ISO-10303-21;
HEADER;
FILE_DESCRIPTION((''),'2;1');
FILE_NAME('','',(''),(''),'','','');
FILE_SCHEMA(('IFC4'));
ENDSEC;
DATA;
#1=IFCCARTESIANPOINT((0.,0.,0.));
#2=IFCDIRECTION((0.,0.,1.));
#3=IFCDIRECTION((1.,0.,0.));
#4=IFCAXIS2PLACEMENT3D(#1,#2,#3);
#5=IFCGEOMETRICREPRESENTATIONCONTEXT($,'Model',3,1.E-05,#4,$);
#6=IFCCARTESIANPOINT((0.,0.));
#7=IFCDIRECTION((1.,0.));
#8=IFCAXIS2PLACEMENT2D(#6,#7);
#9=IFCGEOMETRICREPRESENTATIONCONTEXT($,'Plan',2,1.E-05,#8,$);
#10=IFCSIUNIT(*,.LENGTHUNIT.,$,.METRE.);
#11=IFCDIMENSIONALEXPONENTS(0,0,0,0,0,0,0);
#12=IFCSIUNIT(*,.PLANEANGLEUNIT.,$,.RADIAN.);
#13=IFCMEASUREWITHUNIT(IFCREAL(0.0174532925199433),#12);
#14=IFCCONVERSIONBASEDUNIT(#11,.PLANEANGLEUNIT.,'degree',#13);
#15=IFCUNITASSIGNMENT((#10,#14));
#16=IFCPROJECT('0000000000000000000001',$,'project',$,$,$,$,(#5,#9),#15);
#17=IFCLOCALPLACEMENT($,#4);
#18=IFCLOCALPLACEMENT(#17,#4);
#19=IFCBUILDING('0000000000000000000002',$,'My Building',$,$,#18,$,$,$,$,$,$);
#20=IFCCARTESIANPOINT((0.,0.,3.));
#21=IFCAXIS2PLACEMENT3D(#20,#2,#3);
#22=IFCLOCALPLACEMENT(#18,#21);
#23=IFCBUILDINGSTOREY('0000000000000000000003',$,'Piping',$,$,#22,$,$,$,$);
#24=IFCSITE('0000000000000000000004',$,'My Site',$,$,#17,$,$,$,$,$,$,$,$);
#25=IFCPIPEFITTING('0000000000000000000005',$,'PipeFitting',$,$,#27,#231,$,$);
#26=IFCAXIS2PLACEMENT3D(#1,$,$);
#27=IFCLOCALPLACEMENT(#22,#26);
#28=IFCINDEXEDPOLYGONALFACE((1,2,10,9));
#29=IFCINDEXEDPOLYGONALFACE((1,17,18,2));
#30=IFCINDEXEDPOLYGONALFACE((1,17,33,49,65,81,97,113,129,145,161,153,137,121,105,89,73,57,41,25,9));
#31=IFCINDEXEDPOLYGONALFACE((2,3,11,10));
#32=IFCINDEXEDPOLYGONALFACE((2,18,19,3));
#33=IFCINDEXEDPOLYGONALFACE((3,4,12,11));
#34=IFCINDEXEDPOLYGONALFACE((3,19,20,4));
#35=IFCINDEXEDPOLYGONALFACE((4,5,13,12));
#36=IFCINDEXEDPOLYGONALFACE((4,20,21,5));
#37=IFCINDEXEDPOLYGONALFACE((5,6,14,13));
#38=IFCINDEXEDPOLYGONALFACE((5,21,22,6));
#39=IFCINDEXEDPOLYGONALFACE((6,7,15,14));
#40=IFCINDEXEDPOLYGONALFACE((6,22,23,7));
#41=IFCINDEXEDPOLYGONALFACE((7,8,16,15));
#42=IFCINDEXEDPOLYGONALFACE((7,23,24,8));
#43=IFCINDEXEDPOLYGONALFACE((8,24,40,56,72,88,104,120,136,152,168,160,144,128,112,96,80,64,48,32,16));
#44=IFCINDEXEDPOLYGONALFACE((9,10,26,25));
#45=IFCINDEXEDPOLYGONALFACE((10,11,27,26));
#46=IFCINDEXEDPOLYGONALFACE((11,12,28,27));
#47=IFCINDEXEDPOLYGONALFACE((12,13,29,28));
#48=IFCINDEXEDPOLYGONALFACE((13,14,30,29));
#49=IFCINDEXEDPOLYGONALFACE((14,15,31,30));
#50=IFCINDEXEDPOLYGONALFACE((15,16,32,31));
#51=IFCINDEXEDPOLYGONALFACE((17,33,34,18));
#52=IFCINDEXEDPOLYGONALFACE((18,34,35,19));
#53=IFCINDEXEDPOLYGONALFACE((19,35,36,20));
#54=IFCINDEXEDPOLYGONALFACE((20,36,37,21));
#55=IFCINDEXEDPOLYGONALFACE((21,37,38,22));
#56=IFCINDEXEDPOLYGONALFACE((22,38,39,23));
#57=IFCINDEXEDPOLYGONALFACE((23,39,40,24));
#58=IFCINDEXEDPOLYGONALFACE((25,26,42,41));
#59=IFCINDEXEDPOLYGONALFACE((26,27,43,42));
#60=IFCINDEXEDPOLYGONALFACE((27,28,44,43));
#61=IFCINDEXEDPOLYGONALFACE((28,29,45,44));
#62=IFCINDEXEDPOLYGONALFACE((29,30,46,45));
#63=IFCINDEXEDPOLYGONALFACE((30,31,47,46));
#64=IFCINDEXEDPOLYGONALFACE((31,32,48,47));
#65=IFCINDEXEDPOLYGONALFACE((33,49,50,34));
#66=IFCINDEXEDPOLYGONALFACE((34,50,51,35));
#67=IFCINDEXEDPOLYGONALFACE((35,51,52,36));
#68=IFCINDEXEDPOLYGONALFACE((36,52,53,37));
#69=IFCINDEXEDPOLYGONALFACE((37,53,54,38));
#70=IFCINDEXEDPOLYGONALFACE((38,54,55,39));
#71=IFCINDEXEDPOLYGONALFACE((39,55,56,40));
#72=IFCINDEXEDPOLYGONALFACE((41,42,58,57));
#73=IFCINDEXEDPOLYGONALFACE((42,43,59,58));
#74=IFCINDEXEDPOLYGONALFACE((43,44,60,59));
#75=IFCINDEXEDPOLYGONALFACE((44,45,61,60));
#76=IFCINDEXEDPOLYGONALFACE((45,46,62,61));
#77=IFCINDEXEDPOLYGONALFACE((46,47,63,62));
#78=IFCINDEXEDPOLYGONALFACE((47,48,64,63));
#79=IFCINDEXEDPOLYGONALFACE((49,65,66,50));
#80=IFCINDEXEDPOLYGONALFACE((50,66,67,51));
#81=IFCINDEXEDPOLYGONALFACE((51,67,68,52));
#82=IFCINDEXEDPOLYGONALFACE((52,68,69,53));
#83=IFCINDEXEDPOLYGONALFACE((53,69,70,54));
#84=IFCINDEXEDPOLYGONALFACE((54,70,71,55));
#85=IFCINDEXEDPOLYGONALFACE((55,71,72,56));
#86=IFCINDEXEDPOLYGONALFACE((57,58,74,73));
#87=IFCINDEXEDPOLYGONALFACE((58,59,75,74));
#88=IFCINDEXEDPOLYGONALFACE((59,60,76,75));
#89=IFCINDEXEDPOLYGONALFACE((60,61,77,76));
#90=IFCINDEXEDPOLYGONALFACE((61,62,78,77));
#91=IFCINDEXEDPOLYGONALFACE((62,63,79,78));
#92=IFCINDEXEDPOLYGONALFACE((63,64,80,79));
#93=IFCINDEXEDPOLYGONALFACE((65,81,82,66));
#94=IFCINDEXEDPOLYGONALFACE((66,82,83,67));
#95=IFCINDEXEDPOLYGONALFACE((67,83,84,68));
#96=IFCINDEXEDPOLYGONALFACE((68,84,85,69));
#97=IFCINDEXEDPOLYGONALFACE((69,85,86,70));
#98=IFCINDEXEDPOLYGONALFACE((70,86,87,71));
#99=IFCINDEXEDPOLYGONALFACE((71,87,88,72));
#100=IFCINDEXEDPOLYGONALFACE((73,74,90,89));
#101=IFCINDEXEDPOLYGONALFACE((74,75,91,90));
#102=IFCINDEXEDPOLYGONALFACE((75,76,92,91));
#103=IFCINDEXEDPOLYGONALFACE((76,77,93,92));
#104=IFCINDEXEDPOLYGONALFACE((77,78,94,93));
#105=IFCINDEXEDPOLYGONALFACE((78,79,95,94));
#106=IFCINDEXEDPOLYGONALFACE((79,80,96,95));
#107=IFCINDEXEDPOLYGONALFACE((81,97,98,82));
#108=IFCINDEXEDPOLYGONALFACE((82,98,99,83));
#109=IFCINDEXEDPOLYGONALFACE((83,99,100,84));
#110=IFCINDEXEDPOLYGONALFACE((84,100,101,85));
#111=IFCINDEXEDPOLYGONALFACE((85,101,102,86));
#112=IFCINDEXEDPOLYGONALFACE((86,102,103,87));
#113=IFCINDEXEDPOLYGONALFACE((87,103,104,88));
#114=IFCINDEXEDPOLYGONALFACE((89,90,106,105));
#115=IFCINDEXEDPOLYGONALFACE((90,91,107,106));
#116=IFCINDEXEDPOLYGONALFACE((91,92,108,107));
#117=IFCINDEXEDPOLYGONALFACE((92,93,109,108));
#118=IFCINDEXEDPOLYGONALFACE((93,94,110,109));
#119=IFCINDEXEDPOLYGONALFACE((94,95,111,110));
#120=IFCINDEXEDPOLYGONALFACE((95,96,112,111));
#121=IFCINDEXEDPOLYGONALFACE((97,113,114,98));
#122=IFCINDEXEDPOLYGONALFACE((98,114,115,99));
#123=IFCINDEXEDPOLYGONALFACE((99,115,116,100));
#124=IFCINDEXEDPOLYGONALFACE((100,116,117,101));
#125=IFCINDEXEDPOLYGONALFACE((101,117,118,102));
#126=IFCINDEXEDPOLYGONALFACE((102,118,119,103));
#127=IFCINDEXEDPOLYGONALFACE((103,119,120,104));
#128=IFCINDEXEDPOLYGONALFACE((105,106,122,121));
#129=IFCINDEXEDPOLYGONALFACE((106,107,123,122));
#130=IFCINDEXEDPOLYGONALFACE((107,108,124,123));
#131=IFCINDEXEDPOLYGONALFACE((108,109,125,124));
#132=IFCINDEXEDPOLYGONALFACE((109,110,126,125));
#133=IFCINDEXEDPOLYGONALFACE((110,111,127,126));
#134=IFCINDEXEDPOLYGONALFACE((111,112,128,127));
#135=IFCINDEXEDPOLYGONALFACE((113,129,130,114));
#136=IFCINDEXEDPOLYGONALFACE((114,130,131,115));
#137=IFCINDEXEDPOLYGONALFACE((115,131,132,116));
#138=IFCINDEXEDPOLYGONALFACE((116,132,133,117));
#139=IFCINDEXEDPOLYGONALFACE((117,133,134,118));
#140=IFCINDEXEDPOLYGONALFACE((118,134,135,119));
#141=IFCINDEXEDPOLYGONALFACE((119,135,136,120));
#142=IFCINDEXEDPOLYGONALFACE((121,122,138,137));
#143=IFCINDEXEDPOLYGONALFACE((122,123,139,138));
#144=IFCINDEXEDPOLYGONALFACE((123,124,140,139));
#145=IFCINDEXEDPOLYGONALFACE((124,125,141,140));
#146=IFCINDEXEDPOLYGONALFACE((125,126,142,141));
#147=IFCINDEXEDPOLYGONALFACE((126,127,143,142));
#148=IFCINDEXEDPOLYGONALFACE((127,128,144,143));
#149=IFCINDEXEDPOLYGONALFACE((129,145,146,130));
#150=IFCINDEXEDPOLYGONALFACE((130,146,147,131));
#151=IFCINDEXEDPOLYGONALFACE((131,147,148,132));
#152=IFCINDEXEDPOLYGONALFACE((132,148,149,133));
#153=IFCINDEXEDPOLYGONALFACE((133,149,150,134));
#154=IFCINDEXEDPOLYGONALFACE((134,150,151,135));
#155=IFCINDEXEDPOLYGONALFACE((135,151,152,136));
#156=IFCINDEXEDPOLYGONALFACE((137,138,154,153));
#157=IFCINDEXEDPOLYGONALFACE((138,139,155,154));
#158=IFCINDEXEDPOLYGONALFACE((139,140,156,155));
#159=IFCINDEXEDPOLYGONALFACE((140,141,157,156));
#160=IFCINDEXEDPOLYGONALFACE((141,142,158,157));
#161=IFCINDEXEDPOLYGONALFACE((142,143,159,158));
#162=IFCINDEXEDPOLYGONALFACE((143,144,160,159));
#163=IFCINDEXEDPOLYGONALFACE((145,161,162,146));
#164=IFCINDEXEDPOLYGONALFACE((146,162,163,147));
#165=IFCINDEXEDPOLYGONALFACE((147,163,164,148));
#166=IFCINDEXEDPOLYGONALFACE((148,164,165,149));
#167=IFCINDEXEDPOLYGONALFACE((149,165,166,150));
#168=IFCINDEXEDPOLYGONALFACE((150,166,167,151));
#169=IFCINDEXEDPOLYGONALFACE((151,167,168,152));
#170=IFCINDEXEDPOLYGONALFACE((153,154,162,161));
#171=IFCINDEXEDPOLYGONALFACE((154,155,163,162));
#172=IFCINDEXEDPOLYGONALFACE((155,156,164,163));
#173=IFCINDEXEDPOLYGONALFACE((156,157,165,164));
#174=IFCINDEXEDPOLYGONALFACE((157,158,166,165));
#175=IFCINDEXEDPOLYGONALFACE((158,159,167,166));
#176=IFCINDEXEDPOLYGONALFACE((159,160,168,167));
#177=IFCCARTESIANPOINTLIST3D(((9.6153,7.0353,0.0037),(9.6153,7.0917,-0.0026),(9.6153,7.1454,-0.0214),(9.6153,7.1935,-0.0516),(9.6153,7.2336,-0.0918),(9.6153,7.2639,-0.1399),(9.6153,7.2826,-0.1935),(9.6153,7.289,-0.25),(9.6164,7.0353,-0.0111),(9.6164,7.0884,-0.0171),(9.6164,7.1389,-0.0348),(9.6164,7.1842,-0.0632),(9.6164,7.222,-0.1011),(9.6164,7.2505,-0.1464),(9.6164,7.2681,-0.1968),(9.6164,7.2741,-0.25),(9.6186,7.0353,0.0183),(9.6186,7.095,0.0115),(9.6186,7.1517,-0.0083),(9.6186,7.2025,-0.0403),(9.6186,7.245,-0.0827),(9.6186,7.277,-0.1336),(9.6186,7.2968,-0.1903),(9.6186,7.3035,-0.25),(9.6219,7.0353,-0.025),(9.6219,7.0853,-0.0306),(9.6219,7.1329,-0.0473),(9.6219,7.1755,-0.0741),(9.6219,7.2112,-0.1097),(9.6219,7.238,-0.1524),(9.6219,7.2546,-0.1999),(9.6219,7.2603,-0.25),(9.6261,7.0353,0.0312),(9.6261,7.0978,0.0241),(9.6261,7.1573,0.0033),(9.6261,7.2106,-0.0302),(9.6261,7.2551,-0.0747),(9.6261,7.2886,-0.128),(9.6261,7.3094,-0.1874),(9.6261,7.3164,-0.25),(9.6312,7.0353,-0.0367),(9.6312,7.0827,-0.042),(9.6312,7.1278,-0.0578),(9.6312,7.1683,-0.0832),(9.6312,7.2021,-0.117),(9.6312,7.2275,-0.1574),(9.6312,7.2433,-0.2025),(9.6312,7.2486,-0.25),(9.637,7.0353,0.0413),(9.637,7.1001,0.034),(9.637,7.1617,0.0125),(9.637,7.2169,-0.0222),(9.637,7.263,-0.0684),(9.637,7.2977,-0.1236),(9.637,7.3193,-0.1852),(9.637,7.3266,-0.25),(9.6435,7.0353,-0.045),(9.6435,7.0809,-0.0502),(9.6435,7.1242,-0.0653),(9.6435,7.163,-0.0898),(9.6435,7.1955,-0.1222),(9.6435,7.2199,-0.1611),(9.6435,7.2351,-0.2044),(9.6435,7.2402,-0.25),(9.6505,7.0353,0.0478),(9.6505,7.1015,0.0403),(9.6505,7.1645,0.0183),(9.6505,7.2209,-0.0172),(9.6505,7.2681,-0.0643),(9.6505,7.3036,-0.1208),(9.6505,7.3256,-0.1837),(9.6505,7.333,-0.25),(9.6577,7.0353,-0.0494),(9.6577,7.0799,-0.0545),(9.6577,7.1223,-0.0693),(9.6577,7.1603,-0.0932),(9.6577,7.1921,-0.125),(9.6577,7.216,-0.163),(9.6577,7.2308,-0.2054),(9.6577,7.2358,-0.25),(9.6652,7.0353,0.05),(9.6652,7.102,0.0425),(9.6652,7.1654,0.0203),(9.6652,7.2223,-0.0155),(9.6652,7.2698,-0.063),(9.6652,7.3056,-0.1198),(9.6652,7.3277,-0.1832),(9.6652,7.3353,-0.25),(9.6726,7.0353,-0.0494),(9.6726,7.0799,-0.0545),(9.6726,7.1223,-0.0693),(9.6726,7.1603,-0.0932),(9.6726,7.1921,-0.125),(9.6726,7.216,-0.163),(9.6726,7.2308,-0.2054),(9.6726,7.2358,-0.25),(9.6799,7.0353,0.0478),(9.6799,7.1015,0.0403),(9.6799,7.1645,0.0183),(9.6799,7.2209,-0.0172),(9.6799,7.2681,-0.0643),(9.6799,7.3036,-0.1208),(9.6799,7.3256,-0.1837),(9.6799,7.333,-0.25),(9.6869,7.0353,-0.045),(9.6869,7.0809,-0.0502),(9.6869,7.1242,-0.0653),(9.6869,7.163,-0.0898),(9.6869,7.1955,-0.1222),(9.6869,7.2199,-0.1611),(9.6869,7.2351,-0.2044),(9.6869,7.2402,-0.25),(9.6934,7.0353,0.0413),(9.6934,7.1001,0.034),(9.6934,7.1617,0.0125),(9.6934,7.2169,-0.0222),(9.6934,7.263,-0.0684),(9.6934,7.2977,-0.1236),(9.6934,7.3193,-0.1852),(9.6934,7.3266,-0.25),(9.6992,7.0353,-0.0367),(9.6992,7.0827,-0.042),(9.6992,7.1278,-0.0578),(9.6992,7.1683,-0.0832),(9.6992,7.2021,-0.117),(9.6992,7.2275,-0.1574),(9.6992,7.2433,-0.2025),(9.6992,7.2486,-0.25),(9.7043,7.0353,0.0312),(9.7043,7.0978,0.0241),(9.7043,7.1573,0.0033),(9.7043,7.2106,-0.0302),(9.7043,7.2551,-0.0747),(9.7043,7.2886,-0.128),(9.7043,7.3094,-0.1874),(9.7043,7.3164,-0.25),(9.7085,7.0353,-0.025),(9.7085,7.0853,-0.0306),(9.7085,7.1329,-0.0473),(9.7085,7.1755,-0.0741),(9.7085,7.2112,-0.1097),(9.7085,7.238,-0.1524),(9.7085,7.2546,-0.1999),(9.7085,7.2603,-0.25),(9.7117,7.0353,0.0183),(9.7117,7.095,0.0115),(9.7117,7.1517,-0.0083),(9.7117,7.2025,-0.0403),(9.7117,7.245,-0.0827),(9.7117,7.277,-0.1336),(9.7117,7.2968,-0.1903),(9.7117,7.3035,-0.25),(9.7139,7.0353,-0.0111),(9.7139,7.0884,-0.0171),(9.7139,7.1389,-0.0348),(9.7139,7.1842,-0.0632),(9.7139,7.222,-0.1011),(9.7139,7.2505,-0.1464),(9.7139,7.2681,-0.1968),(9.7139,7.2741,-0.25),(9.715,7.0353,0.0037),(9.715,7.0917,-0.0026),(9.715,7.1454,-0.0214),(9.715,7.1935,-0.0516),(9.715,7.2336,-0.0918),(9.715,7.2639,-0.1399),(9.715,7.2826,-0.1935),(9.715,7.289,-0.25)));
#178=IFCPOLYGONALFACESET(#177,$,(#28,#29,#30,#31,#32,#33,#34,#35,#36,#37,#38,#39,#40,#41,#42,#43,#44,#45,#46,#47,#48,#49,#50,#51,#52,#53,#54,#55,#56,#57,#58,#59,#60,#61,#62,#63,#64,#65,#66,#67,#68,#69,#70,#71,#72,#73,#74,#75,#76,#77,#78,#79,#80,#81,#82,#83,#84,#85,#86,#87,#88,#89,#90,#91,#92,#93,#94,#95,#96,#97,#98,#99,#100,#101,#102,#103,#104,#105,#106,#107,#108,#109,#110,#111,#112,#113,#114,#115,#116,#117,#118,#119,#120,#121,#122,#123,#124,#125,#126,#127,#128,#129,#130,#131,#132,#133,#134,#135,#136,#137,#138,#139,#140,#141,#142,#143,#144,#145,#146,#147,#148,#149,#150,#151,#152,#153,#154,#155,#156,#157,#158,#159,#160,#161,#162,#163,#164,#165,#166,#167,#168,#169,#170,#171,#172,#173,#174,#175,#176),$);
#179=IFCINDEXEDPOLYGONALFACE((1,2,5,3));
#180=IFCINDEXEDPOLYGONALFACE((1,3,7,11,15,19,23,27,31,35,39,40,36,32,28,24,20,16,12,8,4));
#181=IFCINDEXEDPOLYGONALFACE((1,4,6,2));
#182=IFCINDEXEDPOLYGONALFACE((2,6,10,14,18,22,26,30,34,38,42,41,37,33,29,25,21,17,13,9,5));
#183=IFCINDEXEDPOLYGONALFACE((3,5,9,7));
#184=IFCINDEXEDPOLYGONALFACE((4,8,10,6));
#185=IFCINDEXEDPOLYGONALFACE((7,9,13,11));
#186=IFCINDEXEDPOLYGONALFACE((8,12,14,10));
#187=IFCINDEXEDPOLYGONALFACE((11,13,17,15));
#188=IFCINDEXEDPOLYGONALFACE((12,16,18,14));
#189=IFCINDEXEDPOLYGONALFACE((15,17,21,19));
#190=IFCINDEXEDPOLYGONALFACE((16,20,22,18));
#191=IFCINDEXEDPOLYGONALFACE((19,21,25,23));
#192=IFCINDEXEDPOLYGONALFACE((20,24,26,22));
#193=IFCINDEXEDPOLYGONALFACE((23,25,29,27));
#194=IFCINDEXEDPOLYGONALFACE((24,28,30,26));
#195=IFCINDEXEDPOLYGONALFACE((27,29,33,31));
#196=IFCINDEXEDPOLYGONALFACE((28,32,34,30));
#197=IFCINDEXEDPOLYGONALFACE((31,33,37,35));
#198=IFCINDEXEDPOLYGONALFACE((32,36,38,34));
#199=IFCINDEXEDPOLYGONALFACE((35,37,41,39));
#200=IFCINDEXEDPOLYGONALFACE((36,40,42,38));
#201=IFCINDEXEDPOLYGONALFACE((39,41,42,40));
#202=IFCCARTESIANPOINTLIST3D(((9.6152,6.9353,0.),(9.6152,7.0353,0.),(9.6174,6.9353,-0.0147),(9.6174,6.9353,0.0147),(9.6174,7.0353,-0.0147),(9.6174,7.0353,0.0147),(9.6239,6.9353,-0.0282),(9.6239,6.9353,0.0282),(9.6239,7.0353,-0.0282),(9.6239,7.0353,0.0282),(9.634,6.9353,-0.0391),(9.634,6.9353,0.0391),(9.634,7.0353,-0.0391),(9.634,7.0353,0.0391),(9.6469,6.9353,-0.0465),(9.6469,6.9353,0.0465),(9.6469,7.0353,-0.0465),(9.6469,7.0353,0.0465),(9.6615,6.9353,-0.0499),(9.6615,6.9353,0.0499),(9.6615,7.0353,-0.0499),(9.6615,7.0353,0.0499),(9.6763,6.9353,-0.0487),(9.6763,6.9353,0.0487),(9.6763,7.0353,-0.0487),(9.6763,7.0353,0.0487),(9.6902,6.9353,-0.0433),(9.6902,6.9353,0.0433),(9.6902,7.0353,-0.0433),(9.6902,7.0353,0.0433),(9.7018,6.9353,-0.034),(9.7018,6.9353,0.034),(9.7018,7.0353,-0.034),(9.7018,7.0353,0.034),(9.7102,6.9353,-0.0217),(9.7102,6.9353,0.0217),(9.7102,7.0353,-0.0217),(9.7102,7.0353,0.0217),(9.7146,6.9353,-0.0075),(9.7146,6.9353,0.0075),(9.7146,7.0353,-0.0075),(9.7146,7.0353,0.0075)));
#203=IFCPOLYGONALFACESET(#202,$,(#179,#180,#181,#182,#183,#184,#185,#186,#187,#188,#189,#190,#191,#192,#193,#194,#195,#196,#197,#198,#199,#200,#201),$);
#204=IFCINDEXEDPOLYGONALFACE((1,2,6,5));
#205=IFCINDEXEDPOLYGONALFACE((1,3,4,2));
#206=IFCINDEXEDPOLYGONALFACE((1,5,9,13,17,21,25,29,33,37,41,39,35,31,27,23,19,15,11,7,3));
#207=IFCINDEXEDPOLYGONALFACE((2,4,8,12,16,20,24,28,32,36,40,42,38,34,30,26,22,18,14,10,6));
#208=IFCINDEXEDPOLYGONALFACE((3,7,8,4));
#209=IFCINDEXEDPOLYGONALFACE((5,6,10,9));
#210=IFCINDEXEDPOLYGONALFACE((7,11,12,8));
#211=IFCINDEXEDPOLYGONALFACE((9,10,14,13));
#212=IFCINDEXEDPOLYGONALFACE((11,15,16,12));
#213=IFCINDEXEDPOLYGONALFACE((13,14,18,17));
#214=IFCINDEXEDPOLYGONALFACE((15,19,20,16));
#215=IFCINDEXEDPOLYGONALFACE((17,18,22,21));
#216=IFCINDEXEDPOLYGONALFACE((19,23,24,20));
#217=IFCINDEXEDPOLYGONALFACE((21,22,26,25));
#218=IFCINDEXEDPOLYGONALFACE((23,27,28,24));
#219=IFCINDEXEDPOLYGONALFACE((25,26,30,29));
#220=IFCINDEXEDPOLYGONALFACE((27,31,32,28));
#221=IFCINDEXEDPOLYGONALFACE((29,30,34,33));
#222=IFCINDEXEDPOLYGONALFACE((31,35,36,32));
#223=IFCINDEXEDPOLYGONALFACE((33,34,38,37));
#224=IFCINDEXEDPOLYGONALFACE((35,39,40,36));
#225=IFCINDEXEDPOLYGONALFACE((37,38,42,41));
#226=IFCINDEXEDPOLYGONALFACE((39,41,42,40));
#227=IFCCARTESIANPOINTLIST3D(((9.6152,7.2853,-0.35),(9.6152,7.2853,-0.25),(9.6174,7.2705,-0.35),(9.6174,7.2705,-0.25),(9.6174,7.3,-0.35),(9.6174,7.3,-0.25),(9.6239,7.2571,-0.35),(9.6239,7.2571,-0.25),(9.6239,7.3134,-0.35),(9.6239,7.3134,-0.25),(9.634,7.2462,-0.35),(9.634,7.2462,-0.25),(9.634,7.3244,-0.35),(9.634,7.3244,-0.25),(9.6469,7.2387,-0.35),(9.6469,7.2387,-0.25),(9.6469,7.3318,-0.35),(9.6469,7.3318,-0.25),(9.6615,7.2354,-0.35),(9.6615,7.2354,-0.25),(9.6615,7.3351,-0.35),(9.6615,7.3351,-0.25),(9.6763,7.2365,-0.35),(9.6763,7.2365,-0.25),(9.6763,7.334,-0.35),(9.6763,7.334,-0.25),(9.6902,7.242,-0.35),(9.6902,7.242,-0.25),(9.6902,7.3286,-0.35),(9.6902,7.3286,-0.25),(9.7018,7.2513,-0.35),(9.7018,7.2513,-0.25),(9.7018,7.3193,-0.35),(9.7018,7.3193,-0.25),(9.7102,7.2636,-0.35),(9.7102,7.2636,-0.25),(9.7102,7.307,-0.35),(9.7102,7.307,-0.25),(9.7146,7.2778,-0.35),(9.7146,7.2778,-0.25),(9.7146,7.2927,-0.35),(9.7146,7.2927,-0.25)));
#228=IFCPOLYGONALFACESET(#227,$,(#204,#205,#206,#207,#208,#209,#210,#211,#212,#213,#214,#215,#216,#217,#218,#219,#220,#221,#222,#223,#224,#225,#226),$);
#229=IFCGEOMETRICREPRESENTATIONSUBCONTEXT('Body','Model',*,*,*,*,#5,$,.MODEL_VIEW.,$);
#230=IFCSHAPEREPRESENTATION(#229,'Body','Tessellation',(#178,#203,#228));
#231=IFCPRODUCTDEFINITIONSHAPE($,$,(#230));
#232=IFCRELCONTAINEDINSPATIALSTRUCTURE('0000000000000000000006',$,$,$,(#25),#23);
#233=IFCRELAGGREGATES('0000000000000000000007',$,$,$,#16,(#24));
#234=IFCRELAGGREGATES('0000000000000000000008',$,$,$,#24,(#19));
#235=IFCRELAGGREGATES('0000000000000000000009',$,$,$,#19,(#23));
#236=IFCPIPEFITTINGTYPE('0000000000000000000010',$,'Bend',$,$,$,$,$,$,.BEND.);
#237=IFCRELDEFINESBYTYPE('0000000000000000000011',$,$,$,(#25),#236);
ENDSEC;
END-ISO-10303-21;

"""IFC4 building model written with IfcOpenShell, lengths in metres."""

from ifc_helpers import new_model, entity, si_unit, converted_unit, frame, origin_with_axes, origin_2d_with_axis, place, context, subcontext, project, spatial, circle, extrude, source, transform, mapped, type_object, type_shapes, element, save


model = new_model("IFC4")

# Units and contexts
model_context = context("Model", 3, precision=1e-05, world=origin_with_axes())
plan_context = context("Plan", 2, precision=1e-05, world=origin_2d_with_axis())
body_context = subcontext(model_context, "Body", "Model", "MODEL_VIEW")
ifc_project = project(units=[si_unit("LENGTHUNIT", "METRE"), converted_unit("PLANEANGLEUNIT", "degree", entity("IfcReal", 0.0174532925199433), si_unit("PLANEANGLEUNIT", "RADIAN"), dimensions=[0, 0, 0, 0, 0, 0, 0])], contexts=[model_context, plan_context])

# Site, building, storey
site_placement = place(None, origin_with_axes())
site = spatial("IfcSite", under=ifc_project, at=site_placement, Name="My Site")
building_placement = place(site_placement, origin_with_axes())
building = spatial("IfcBuilding", under=site, at=building_placement, Name="My Building")
storey_placement = place(building_placement, frame((0.0, 0.0, 3.0), z_axis=(0.0, 0.0, 1.0), x_axis=(1.0, 0.0, 0.0)))
storey = spatial("IfcBuildingStorey", under=building, at=storey_placement, Name="Piping")

# Pipe fitting
pipe_fitting_type_1 = type_object("IfcPipeFittingType", Name="Bend", PredefinedType="BEND")
shared_shape = source(origin_with_axes(), body_context, "Body", "SolidModel", [
    entity("IfcSweptDiskSolid", entity("IfcIndexedPolyCurve", entity("IfcCartesianPointList3D", [[0.0, 0.0, -0.1], [0.0, 0.0732, -0.2768], [0.0, 0.25, -0.35]]), [entity("IfcArcIndex", [1, 2, 3])]), 0.05),
    extrude(circle(Radius=0.05), origin_with_axes(), (0.0, 0.0, -1.0), 0.1),
    extrude(circle(Radius=0.05), frame((0.0, 0.25, -0.35), z_axis=(0.0, 1.0, 0.0), x_axis=(1.0, 0.0, 0.0)), (0.0, 0.0, 1.0), 0.1),
])
type_shapes(pipe_fitting_type_1, [shared_shape])
for number, where, z_axis, x_axis, name in (
    (1, (9.6652, 6.9353, 0.0), (0.0, -1.0, 0.0), (-1.0, 0.0, 0.0), "PipeFitting"),
):
    element("IfcPipeFitting", number, at=place(storey_placement, frame(where, z_axis=z_axis, x_axis=x_axis)), inside=storey, type_object=pipe_fitting_type_1, Name=name, context=body_context, shape_type="MappedRepresentation", body=[
        mapped(shared_shape, transform((0.0, 0.0, 0.0), x_axis=(1.0, 0.0, 0.0), y_axis=(0.0, 1.0, 0.0), z_axis=(0.0, 0.0, 1.0), scale=1.0)),
    ])

save(model, "model.ifc")
